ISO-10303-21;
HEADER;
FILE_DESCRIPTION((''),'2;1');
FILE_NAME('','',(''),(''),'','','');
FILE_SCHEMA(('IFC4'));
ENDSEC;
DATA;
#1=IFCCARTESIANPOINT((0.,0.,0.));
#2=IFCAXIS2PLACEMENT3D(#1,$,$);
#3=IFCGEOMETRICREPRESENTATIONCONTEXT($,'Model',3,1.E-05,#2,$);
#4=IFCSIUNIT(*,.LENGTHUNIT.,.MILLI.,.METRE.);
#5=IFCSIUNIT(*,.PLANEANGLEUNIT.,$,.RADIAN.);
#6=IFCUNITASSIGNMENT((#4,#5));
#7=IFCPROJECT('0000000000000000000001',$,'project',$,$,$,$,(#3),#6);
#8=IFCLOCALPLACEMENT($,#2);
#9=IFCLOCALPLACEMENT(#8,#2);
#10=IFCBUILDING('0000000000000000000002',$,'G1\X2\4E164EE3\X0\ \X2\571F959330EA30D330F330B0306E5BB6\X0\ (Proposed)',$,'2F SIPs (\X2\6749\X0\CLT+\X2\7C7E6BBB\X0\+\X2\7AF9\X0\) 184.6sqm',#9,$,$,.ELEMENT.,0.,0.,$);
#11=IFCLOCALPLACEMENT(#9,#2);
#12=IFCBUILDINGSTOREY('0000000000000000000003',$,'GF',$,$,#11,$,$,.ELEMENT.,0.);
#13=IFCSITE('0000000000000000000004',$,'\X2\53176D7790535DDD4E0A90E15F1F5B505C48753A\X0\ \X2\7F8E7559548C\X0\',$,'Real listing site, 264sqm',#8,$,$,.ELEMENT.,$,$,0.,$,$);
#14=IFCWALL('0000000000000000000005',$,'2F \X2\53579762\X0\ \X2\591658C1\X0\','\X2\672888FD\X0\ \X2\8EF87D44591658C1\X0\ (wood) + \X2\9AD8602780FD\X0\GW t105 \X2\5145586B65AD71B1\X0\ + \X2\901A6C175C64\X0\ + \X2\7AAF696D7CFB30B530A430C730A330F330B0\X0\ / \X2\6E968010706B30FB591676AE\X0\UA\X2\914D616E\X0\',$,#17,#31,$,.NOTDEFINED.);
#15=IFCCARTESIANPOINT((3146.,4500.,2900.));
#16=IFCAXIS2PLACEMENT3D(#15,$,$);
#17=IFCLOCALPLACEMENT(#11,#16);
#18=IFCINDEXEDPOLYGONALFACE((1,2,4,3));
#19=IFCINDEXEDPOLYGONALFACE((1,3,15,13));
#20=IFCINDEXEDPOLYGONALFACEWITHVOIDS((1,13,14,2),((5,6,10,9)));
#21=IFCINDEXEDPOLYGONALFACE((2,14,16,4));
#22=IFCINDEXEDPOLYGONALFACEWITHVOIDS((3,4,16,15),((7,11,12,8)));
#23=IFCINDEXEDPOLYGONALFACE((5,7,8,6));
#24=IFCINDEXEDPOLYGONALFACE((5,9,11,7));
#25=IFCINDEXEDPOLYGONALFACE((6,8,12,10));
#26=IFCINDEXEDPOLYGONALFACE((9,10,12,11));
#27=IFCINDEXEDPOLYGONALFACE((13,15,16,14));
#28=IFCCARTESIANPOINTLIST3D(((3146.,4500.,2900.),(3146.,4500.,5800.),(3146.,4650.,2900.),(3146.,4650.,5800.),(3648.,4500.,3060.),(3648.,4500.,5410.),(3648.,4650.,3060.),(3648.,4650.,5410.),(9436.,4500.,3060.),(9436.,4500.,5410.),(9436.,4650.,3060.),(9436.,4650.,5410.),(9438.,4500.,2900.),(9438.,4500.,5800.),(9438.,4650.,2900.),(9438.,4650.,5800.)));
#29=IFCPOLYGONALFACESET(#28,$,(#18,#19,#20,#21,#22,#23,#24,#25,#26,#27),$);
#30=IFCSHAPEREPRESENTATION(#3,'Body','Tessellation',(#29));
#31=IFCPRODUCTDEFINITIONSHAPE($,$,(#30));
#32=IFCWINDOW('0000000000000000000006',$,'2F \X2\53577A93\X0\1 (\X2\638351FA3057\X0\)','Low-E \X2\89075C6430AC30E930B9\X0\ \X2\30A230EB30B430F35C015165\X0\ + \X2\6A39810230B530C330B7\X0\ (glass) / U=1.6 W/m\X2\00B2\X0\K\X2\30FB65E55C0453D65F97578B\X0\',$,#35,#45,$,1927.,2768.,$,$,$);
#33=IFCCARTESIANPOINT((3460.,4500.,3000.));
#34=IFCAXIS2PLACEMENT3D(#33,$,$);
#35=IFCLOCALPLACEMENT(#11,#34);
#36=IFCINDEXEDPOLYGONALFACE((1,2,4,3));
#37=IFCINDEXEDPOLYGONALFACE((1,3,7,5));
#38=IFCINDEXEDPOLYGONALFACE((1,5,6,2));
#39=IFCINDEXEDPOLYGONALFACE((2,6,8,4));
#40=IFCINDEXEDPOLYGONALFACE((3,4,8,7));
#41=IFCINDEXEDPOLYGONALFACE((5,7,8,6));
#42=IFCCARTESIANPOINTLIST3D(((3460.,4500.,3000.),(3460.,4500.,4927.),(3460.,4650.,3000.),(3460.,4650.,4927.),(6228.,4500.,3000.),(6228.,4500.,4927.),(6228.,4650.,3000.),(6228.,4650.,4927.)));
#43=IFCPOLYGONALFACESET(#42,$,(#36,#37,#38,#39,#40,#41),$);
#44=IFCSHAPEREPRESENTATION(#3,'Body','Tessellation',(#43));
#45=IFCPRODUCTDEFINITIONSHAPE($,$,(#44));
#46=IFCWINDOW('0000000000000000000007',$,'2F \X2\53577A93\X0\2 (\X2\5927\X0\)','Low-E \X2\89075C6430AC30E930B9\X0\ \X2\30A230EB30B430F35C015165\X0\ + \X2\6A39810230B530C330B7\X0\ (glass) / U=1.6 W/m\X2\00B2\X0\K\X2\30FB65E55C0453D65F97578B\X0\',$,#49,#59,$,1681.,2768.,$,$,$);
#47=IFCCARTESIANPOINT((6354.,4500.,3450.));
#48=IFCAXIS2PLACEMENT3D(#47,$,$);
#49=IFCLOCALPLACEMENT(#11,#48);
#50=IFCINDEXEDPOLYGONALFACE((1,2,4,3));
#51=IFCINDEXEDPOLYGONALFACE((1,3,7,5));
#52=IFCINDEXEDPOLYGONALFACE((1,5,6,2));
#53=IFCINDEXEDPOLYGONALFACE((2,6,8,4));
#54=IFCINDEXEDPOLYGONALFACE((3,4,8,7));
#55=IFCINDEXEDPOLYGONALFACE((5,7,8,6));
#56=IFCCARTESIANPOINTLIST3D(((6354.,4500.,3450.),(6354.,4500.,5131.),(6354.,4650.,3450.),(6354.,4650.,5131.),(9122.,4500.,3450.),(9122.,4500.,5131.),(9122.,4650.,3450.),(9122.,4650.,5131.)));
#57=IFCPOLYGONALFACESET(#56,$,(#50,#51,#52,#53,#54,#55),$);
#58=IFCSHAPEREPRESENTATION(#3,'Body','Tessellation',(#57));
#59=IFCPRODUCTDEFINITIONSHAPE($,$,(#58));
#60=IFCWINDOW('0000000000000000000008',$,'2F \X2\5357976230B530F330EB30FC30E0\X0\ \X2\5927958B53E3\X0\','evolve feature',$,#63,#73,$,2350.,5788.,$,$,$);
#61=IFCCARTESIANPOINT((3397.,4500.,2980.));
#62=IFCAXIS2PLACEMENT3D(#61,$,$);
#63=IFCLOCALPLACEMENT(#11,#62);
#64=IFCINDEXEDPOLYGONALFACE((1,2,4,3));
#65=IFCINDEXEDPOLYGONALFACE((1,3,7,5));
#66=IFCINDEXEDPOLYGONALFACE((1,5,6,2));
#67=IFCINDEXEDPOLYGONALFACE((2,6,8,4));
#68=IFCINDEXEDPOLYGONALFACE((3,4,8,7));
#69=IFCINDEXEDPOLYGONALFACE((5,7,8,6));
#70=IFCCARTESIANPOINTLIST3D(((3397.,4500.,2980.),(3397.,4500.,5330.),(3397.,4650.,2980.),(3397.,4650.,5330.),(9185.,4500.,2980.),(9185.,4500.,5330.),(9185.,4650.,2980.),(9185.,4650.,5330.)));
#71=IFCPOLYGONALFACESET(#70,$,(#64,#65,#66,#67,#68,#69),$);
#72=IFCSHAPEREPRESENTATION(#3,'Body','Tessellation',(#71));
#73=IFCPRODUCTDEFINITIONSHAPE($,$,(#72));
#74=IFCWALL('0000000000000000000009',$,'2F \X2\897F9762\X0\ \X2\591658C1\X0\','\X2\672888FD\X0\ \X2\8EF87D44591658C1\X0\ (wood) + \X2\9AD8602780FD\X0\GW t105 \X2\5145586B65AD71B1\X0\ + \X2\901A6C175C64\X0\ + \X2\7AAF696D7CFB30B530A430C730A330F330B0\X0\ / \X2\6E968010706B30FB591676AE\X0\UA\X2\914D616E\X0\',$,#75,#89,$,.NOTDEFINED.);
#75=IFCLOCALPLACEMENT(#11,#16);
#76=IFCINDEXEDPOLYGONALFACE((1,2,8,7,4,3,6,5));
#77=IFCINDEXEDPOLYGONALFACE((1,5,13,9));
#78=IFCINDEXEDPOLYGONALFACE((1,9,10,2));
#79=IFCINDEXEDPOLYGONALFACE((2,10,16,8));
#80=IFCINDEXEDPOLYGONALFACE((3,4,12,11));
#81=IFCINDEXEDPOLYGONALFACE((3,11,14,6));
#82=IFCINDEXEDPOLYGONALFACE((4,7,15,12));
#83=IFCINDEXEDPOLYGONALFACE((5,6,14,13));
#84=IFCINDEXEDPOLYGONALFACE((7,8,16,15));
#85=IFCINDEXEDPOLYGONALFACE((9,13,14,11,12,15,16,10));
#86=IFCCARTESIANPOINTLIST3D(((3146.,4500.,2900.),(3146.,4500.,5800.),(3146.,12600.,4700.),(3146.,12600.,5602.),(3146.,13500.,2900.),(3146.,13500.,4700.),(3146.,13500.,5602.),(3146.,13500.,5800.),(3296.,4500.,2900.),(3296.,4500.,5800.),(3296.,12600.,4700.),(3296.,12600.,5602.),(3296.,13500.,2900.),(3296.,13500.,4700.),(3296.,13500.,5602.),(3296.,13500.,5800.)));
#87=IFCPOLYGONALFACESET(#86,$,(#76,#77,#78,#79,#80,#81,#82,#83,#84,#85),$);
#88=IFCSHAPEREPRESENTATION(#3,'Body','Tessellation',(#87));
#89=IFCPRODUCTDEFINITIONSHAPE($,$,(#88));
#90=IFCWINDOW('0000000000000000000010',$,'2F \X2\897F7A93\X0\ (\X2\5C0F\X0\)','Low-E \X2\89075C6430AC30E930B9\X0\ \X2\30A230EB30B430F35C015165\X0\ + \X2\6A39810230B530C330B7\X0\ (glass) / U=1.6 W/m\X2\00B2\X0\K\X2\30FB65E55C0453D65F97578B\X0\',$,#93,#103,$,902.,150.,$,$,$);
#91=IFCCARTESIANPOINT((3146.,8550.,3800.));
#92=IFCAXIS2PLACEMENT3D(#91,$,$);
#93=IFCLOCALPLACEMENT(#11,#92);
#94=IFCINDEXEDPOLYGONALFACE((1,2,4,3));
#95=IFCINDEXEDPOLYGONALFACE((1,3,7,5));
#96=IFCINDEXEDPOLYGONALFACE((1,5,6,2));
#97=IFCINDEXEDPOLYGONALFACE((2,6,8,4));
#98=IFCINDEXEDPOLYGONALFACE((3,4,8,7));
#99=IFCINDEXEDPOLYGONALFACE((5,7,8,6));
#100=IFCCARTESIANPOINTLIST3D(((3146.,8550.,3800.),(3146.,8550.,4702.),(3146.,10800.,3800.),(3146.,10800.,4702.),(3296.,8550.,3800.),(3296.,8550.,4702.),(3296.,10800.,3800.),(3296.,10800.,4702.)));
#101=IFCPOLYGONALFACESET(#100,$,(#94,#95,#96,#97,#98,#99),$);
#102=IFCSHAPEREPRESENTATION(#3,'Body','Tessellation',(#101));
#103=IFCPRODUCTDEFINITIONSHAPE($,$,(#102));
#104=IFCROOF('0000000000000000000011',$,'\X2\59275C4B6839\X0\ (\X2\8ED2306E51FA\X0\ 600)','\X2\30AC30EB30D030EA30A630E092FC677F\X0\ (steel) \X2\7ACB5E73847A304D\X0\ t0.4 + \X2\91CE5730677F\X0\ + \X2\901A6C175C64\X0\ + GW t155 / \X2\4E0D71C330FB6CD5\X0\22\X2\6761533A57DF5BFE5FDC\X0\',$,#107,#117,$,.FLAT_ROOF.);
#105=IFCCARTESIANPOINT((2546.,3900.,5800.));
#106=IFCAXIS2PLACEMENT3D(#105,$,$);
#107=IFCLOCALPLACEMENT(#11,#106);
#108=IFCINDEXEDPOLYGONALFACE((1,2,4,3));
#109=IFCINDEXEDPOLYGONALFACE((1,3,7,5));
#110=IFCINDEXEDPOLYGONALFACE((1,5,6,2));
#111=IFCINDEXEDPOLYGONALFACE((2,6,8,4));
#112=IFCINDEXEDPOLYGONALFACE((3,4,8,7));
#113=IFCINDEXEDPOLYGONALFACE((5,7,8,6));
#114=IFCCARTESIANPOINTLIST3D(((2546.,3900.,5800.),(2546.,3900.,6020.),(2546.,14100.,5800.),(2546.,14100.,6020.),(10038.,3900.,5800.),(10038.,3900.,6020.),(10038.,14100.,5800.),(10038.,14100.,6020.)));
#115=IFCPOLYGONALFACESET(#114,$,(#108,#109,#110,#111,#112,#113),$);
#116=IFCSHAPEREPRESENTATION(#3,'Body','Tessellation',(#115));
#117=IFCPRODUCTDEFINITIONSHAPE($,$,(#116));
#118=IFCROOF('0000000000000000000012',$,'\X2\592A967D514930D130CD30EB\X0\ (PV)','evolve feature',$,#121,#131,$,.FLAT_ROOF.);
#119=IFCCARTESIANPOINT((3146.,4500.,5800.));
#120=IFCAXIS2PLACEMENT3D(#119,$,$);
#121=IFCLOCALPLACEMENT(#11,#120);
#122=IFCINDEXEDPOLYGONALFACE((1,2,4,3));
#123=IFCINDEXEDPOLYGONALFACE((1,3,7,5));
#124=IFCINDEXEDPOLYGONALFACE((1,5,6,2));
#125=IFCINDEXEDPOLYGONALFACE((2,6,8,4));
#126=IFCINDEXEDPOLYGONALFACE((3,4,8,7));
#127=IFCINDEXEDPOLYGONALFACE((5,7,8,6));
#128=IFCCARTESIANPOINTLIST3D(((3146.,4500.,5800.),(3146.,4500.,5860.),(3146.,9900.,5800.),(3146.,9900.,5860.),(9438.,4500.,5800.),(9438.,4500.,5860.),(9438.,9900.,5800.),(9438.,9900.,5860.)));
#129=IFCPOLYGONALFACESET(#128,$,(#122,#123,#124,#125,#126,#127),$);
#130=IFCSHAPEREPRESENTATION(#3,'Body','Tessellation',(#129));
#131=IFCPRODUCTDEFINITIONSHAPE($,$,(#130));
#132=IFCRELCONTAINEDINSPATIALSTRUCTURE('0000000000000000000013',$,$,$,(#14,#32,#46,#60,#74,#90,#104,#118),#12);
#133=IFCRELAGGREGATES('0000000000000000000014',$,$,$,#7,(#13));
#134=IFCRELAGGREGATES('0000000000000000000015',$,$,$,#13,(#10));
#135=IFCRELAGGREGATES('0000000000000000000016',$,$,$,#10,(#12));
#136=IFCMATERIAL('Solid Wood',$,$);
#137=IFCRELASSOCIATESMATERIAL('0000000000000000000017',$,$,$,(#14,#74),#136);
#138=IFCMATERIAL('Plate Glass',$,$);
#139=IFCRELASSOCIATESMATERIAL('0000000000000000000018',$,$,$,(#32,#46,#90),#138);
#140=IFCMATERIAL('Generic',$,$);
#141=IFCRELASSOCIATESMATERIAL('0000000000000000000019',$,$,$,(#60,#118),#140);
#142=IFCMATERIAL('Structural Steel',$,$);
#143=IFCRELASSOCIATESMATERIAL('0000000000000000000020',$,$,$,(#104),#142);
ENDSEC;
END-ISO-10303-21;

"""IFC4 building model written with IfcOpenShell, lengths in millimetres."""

from ifc_helpers import new_model, si_unit, frame, frame_2d, origin, place, context, project, spatial, rectangle, extrude, material, element, fill, save


model = new_model("IFC4")

# Units and contexts
model_context = context("Model", 3, precision=1e-05, world=origin())
ifc_project = project(units=[si_unit("LENGTHUNIT", "METRE", prefix="MILLI"), si_unit("PLANEANGLEUNIT", "RADIAN")], contexts=[model_context])

# Site, building, storey
site_placement = place(None, origin())
site = spatial("IfcSite", under=ifc_project, at=site_placement, Name="北海道川上郡弟子屈町 美留和", ObjectType="Real listing site, 264sqm", CompositionType="ELEMENT", RefElevation=0.0)
building_placement = place(site_placement, origin())
building = spatial("IfcBuilding", under=site, at=building_placement, Name="G1世代 土間リビングの家 (Proposed)", ObjectType="2F SIPs (杉CLT+籾殻+竹) 184.6sqm", CompositionType="ELEMENT", ElevationOfRefHeight=0.0, ElevationOfTerrain=0.0)
storey_placement = place(building_placement, origin())
storey = spatial("IfcBuildingStorey", under=building, at=storey_placement, Name="GF", CompositionType="ELEMENT", Elevation=0.0)

# Shared definitions
ifc_material_1 = material(Name="Solid Wood")
ifc_material_2 = material(Name="Generic")

# Shared definitions
ifc_material_3 = material(Name="Plate Glass")

# Wall, openings, windows
wall_1_placement = place(storey_placement, frame((3146.0, 4500.0, 2900.0)))
wall_1 = element("IfcWall", 1, at=wall_1_placement, inside=storey, material=ifc_material_1, Name="2F 南面 外壁", Description="木製 軸組外壁 (wood) + 高性能GW t105 充填断熱 + 通気層 + 窯業系サイディング / 準耐火・外皮UA配慮", PredefinedType="NOTDEFINED", context=model_context, shape_type="SweptSolid", body=[
    extrude(rectangle(XDim=6292.0, YDim=150.0, at=frame_2d((3146.0, 75.0))), frame((3146.0, 4500.0, 2900.0)), (0.0, 0.0, 1.0), 2900.0),
])
opening_1_placement = place(storey_placement, frame((3460.0, 4500.0, 3000.0)))
opening_1 = element("IfcOpeningElement", 2, at=opening_1_placement, cuts=wall_1, PredefinedType="NOTDEFINED", context=model_context, shape_type="SweptSolid", body=[
    extrude(rectangle(XDim=2768.0, YDim=150.0, at=frame_2d((1384.0, 75.0))), frame((3460.0, 4500.0, 3000.0)), (0.0, 0.0, 1.0), 1927.0),
])
opening_2_placement = place(storey_placement, frame((6354.0, 4500.0, 3450.0)))
opening_2 = element("IfcOpeningElement", 3, at=opening_2_placement, cuts=wall_1, PredefinedType="NOTDEFINED", context=model_context, shape_type="SweptSolid", body=[
    extrude(rectangle(XDim=2768.0, YDim=150.0, at=frame_2d((1384.0, 75.0))), frame((6354.0, 4500.0, 3450.0)), (0.0, 0.0, 1.0), 1681.0),
])
opening_3_placement = place(storey_placement, frame((3397.0, 4500.0, 2980.0)))
opening_3 = element("IfcOpeningElement", 4, at=opening_3_placement, cuts=wall_1, PredefinedType="NOTDEFINED", context=model_context, shape_type="SweptSolid", body=[
    extrude(rectangle(XDim=5788.0, YDim=150.0, at=frame_2d((2894.0, 75.0))), frame((3397.0, 4500.0, 2980.0)), (0.0, 0.0, 1.0), 2350.0),
])
window_1_placement = place(storey_placement, frame((3460.0, 4500.0, 3000.0)))
window_1 = element("IfcWindow", 5, at=window_1_placement, inside=storey, material=ifc_material_3, Name="2F 南窓1 (掃出し)", Description="Low-E 複層ガラス アルゴン封入 + 樹脂サッシ (glass) / U=1.6 W/m²K・日射取得型", OverallHeight=1927.0, OverallWidth=2768.0, context=model_context, shape_type="SweptSolid", body=[
    extrude(rectangle(XDim=2768.0, YDim=150.0, at=frame_2d((1384.0, 75.0))), frame((3460.0, 4500.0, 3000.0)), (0.0, 0.0, 1.0), 1927.0),
])
fill(opening_1, window_1)
window_2_placement = place(storey_placement, frame((6354.0, 4500.0, 3450.0)))
window_2 = element("IfcWindow", 6, at=window_2_placement, inside=storey, material=ifc_material_3, Name="2F 南窓2 (大)", Description="Low-E 複層ガラス アルゴン封入 + 樹脂サッシ (glass) / U=1.6 W/m²K・日射取得型", OverallHeight=1681.0, OverallWidth=2768.0, context=model_context, shape_type="SweptSolid", body=[
    extrude(rectangle(XDim=2768.0, YDim=150.0, at=frame_2d((1384.0, 75.0))), frame((6354.0, 4500.0, 3450.0)), (0.0, 0.0, 1.0), 1681.0),
])
fill(opening_2, window_2)
window_3_placement = place(storey_placement, frame((3397.0, 4500.0, 2980.0)))
window_3 = element("IfcWindow", 7, at=window_3_placement, inside=storey, material=ifc_material_2, Name="2F 南面サンルーム 大開口", Description="evolve feature", OverallHeight=2350.0, OverallWidth=5788.0, context=model_context, shape_type="SweptSolid", body=[
    extrude(rectangle(XDim=5788.0, YDim=150.0, at=frame_2d((2894.0, 75.0))), frame((3397.0, 4500.0, 2980.0)), (0.0, 0.0, 1.0), 2350.0),
])
fill(opening_3, window_3)

# Wall, opening, window
wall_2_placement = place(storey_placement, frame((3146.0, 4500.0, 2900.0)))
wall_2 = element("IfcWall", 8, at=wall_2_placement, inside=storey, material=ifc_material_1, Name="2F 西面 外壁", Description="木製 軸組外壁 (wood) + 高性能GW t105 充填断熱 + 通気層 + 窯業系サイディング / 準耐火・外皮UA配慮", PredefinedType="NOTDEFINED", context=model_context, shape_type="SweptSolid", body=[
    extrude(rectangle(XDim=150.0, YDim=9000.0, at=frame_2d((75.0, 4500.0))), frame((3146.0, 4500.0, 2900.0)), (0.0, 0.0, 1.0), 2900.0),
])
opening_4_placement = place(storey_placement, frame((3146.0, 8550.0, 3800.0)))
opening_4 = element("IfcOpeningElement", 9, at=opening_4_placement, cuts=wall_2, PredefinedType="NOTDEFINED", context=model_context, shape_type="SweptSolid", body=[
    extrude(rectangle(XDim=150.0, YDim=2250.0, at=frame_2d((75.0, 1125.0))), frame((3146.0, 8550.0, 3800.0)), (0.0, 0.0, 1.0), 902.0),
])
window_4_placement = place(storey_placement, frame((3146.0, 8550.0, 3800.0)))
window_4 = element("IfcWindow", 10, at=window_4_placement, inside=storey, material=ifc_material_3, Name="2F 西窓 (小)", Description="Low-E 複層ガラス アルゴン封入 + 樹脂サッシ (glass) / U=1.6 W/m²K・日射取得型", OverallHeight=902.0, OverallWidth=150.0, context=model_context, shape_type="SweptSolid", body=[
    extrude(rectangle(XDim=150.0, YDim=2250.0, at=frame_2d((75.0, 1125.0))), frame((3146.0, 8550.0, 3800.0)), (0.0, 0.0, 1.0), 902.0),
])
fill(opening_4, window_4)

# Roofs
ifc_material_4 = material(Name="Structural Steel")
roof_1_placement = place(storey_placement, frame((2546.0, 3900.0, 5800.0)))
element("IfcRoof", 11, at=roof_1_placement, inside=storey, material=ifc_material_4, Name="大屋根 (軒の出 600)", Description="ガルバリウム鋼板 (steel) 立平葺き t0.4 + 野地板 + 通気層 + GW t155 / 不燃・法22条区域対応", PredefinedType="FLAT_ROOF", context=model_context, shape_type="SweptSolid", body=[
    extrude(rectangle(XDim=7492.0, YDim=10200.0, at=frame_2d((3746.0, 5100.0))), frame((2546.0, 3900.0, 5800.0)), (0.0, 0.0, 1.0), 220.0),
])
roof_2_placement = place(storey_placement, frame((3146.0, 4500.0, 5800.0)))
element("IfcRoof", 12, at=roof_2_placement, inside=storey, material=ifc_material_2, Name="太陽光パネル (PV)", Description="evolve feature", PredefinedType="FLAT_ROOF", context=model_context, shape_type="SweptSolid", body=[
    extrude(rectangle(XDim=6292.0, YDim=5400.0, at=frame_2d((3146.0, 2700.0))), frame((3146.0, 4500.0, 5800.0)), (0.0, 0.0, 1.0), 60.0),
])

save(model, "model.ifc")
